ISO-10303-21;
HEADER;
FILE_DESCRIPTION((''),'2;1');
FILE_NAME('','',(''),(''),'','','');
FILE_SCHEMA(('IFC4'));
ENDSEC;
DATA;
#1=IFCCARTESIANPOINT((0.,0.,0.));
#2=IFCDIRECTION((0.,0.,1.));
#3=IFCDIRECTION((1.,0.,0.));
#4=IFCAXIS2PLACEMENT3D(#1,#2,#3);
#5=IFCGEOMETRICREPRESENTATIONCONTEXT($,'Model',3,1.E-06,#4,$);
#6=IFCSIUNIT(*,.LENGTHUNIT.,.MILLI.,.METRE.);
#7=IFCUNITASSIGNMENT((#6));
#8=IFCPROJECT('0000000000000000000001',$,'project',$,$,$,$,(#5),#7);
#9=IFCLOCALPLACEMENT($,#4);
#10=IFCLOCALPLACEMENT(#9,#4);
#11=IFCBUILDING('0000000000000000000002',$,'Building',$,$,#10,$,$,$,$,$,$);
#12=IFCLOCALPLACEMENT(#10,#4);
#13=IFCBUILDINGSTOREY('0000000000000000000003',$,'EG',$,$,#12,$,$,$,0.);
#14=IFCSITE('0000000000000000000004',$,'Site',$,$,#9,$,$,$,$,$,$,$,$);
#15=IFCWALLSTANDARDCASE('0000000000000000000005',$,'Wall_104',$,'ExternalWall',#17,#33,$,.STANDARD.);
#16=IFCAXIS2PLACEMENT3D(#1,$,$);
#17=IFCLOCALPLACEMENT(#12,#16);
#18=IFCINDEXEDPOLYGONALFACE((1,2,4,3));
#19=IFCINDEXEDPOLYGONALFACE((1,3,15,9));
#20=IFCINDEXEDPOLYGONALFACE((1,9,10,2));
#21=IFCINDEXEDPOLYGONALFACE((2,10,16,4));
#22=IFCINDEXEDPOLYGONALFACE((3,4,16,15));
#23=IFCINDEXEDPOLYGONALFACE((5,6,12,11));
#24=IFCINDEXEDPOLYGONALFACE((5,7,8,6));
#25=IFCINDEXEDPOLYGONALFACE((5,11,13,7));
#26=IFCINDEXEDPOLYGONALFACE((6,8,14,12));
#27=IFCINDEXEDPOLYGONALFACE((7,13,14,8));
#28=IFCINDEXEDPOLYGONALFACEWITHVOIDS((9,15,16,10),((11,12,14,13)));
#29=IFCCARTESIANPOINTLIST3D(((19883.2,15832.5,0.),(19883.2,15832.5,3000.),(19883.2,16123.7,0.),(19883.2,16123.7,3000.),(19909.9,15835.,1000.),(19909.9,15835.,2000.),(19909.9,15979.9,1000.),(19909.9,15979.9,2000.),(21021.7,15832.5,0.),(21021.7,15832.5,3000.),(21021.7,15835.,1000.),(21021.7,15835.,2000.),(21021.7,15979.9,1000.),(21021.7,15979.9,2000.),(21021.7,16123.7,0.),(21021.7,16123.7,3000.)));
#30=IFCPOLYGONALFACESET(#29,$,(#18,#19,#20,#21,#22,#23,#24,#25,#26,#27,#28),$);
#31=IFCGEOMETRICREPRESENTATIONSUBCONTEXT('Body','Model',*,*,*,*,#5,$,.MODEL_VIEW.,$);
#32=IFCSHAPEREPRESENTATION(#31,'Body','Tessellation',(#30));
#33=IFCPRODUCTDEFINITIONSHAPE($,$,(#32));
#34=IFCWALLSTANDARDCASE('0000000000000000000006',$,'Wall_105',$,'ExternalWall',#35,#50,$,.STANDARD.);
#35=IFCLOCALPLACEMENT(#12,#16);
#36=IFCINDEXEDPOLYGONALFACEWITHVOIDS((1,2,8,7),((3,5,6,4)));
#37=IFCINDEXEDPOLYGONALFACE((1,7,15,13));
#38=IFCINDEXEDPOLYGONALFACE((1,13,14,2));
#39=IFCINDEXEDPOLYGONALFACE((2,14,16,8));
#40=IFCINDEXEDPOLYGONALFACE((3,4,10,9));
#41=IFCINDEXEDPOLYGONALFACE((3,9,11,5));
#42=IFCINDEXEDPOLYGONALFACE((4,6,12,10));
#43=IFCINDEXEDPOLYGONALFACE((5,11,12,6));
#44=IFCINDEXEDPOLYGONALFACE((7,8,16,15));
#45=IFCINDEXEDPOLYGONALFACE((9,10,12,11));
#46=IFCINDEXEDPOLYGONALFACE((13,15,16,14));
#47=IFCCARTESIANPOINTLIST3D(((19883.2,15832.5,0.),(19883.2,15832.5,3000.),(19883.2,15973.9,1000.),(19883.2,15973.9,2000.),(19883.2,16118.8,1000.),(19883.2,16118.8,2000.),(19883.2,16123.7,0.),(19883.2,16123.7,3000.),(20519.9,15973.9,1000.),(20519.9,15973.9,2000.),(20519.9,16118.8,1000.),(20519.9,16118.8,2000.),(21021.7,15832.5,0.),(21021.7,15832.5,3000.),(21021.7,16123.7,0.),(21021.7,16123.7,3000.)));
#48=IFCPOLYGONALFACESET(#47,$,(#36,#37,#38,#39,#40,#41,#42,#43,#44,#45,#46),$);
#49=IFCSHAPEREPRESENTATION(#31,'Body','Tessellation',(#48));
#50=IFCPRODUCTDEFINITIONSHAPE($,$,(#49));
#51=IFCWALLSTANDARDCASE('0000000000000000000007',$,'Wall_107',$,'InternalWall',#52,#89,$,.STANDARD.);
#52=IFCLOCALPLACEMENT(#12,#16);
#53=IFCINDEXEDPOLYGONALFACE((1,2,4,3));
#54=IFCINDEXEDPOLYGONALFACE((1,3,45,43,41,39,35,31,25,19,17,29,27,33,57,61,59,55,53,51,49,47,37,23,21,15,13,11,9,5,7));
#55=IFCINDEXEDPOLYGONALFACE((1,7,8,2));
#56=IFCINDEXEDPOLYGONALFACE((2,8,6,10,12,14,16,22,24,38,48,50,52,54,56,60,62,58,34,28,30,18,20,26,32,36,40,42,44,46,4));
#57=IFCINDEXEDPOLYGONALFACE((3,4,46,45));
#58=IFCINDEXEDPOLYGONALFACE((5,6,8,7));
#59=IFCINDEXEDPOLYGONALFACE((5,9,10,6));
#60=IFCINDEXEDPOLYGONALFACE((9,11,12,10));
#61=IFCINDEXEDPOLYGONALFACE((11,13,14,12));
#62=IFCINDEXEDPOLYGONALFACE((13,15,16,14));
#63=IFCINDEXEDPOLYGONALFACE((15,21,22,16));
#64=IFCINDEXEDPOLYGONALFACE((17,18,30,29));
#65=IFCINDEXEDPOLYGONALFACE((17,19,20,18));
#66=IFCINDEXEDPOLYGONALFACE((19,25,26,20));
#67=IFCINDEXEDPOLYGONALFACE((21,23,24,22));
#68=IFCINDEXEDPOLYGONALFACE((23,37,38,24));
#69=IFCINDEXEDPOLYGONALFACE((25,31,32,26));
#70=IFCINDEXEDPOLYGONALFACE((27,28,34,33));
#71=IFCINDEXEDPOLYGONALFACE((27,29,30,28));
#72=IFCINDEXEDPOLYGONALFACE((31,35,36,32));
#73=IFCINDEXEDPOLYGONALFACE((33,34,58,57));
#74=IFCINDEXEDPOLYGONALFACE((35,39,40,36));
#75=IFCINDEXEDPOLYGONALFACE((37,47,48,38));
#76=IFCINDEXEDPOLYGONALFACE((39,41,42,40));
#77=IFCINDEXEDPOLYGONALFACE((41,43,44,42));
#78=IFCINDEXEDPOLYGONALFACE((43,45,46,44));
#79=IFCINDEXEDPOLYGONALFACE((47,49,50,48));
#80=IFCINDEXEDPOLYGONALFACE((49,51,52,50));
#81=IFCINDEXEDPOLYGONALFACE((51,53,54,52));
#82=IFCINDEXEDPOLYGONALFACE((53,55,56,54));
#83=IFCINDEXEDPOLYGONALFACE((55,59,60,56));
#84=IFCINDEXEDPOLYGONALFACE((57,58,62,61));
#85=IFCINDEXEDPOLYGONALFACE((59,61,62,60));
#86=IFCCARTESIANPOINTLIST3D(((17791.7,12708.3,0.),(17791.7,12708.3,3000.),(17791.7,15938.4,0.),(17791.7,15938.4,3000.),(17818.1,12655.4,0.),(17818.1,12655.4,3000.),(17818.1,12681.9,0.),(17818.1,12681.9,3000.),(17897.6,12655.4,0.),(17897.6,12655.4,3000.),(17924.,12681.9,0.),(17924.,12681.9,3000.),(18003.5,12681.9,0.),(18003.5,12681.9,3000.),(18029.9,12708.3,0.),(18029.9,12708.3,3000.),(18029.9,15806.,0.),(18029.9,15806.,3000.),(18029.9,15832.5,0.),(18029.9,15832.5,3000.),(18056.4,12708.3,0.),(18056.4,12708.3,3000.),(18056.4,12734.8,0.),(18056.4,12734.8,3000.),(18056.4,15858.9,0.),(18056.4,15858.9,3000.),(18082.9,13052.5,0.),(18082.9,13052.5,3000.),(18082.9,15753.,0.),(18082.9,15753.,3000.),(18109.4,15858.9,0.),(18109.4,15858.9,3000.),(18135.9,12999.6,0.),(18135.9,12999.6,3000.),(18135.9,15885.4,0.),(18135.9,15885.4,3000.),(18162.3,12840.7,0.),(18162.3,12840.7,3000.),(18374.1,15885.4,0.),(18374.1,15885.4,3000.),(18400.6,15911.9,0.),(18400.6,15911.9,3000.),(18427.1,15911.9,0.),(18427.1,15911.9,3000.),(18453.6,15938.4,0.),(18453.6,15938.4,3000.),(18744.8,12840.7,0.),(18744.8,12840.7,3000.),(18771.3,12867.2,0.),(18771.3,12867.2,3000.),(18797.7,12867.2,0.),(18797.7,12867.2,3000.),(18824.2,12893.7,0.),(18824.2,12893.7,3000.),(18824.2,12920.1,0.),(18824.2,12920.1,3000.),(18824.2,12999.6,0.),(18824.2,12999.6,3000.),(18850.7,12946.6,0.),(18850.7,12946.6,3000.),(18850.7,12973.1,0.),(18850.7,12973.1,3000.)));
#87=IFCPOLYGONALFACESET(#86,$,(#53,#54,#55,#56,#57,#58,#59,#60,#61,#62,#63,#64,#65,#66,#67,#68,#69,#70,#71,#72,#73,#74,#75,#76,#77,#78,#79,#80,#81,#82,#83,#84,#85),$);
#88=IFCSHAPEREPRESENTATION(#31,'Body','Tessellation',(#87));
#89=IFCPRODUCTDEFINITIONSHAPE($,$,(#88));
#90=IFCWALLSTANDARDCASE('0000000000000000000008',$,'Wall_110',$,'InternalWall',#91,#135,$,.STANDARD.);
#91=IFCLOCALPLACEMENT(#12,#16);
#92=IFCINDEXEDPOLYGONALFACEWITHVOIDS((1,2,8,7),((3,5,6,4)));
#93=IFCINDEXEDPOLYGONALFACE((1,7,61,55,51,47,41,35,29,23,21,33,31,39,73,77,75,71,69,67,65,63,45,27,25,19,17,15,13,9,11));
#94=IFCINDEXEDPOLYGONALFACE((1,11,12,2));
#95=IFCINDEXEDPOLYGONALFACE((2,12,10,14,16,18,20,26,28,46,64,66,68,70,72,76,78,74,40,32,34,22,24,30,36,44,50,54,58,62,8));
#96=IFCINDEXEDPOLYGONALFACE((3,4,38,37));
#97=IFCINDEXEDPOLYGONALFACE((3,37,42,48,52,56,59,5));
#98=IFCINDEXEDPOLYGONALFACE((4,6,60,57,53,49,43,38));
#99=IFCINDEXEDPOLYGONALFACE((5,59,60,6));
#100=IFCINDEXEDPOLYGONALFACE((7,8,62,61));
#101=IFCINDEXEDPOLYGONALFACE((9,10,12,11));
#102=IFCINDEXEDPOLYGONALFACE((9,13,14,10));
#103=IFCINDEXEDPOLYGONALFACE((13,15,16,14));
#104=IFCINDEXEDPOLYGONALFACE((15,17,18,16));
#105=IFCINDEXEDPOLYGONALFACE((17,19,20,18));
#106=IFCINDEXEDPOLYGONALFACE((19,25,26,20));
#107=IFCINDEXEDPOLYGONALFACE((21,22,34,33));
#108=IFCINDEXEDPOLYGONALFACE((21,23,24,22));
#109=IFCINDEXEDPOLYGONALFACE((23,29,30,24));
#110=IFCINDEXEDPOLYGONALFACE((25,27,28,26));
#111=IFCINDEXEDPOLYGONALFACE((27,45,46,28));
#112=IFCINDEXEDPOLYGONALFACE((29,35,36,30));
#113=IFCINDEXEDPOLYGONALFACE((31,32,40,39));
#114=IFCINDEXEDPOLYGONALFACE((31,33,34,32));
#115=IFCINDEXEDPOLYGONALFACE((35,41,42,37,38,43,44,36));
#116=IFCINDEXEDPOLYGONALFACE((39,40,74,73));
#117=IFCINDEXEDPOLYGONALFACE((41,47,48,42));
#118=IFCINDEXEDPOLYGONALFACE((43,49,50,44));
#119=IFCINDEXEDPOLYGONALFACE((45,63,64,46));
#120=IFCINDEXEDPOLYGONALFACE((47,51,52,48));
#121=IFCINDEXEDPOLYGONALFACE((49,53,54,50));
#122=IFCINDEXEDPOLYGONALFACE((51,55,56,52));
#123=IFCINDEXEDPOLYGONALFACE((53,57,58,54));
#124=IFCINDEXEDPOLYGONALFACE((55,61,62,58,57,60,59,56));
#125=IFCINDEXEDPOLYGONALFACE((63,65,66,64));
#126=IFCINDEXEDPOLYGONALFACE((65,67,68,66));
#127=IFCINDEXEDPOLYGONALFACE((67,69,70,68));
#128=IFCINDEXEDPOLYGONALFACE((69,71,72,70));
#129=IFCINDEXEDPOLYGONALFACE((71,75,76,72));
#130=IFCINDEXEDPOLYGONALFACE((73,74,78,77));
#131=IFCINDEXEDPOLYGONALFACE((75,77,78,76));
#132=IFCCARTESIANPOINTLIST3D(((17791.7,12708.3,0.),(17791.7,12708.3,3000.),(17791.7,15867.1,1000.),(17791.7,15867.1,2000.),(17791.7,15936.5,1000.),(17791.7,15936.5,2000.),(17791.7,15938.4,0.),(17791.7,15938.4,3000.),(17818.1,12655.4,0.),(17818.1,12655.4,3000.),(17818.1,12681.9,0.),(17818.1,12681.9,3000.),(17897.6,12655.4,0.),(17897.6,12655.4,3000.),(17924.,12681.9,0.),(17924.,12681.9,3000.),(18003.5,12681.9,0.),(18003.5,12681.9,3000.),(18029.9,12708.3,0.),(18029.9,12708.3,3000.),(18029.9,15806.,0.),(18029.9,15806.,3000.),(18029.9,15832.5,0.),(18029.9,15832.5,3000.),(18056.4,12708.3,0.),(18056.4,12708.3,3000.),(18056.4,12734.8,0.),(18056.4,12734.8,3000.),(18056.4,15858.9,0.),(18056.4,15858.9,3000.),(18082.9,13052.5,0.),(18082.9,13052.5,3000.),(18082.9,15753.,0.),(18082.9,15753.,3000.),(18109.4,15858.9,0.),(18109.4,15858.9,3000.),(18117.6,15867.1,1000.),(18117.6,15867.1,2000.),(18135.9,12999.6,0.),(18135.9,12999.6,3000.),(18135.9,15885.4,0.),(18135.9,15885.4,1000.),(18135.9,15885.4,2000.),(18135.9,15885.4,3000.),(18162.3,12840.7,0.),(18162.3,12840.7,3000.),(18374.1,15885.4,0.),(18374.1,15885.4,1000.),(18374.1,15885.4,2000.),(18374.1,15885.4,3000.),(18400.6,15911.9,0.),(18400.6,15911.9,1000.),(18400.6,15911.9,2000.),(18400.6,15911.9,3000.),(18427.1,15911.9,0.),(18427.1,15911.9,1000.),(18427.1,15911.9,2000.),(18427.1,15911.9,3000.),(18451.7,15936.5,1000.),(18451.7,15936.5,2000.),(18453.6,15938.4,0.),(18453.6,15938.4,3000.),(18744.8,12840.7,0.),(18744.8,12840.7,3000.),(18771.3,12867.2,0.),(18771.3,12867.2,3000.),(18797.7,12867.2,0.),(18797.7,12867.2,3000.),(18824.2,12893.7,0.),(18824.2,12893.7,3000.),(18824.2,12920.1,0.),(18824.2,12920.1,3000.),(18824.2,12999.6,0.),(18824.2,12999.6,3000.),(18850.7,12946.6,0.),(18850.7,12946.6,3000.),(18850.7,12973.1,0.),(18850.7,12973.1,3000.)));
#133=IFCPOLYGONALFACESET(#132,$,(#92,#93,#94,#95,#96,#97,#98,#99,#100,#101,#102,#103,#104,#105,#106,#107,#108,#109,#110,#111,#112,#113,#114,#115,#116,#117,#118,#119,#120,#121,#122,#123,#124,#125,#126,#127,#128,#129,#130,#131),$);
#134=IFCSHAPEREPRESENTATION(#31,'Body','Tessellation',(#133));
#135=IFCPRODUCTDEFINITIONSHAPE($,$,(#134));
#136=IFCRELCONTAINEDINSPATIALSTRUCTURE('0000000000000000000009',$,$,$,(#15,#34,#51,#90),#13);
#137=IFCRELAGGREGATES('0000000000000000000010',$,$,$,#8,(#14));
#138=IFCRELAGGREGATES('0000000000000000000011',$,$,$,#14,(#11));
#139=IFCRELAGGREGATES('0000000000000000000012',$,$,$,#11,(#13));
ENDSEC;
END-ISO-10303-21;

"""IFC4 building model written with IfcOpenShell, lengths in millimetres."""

from ifc_helpers import new_model, si_unit, frame, origin_with_axes, place, context, subcontext, project, spatial, polyline, rectangle, outline, extrude, element, save


model = new_model("IFC4")

# Units and contexts
model_context = context("Model", 3, precision=1e-06, world=origin_with_axes())
body_context = subcontext(model_context, "Body", "Model", "MODEL_VIEW")
ifc_project = project(units=[si_unit("LENGTHUNIT", "METRE", prefix="MILLI")], contexts=[model_context])

# Site, building, storey
site_placement = place(None, origin_with_axes())
site = spatial("IfcSite", under=ifc_project, at=site_placement, Name="Site")
building_placement = place(site_placement, origin_with_axes())
building = spatial("IfcBuilding", under=site, at=building_placement, Name="Building")
storey_placement = place(building_placement, origin_with_axes())
storey = spatial("IfcBuildingStorey", under=building, at=storey_placement, Name="EG", Elevation=0.0)

# Walls, openings
wall_1_placement = place(storey_placement, origin_with_axes())
wall_1 = element("IfcWallStandardCase", 1, at=wall_1_placement, inside=storey, Name="Wall_104", ObjectType="ExternalWall", PredefinedType="STANDARD", context=body_context, shape_type="SweptSolid", body=[
    extrude(outline(polyline([(19883.2, 15832.5, 0.0), (19883.2, 16123.7, 0.0), (21021.7, 16123.7, 0.0), (21021.7, 15832.5, 0.0), (19883.2, 15832.5, 0.0)])), origin_with_axes(), (0.0, 0.0, 1.0), 3000.0),
])
opening_1_placement = place(wall_1_placement, origin_with_axes())
element("IfcOpeningElement", 2, at=opening_1_placement, inside=storey, cuts=wall_1, context=body_context, shape_type="SweptSolid", body=[
    extrude(rectangle(XDim=2096.8, YDim=144.9), frame((20958.2, 15907.5, 1000.0), z_axis=(0.0, 0.0, 1.0), x_axis=(1.0, 0.0, 0.0)), (0.0, 0.0, 1.0), 1000.0),
])
wall_2_placement = place(storey_placement, origin_with_axes())
wall_2 = element("IfcWallStandardCase", 3, at=wall_2_placement, inside=storey, Name="Wall_105", ObjectType="ExternalWall", PredefinedType="STANDARD", context=body_context, shape_type="SweptSolid", body=[
    extrude(outline(polyline([(19883.2, 15832.5, 0.0), (19883.2, 16123.7, 0.0), (21021.7, 16123.7, 0.0), (21021.7, 15832.5, 0.0), (19883.2, 15832.5, 0.0)])), origin_with_axes(), (0.0, 0.0, 1.0), 3000.0),
])
opening_2_placement = place(wall_2_placement, origin_with_axes())
element("IfcOpeningElement", 4, at=opening_2_placement, inside=storey, cuts=wall_2, context=body_context, shape_type="SweptSolid", body=[
    extrude(rectangle(XDim=1123.3, YDim=144.9), frame((19958.2, 16046.4, 1000.0), z_axis=(0.0, 0.0, 1.0), x_axis=(1.0, 0.0, 0.0)), (0.0, 0.0, 1.0), 1000.0),
])

# Wall
for number, where, z_axis, x_axis, name in (
    (5, (0.0, 0.0, 0.0), (0.0, 0.0, 1.0), (1.0, 0.0, 0.0), "Wall_107"),
):
    element("IfcWallStandardCase", number, at=place(storey_placement, frame(where, z_axis=z_axis, x_axis=x_axis)), inside=storey, Name=name, ObjectType="InternalWall", PredefinedType="STANDARD", context=body_context, shape_type="SweptSolid", body=[
        extrude(outline(polyline([(17818.1, 12655.4, 0.0), (17818.1, 12681.9, 0.0), (17791.7, 12708.3, 0.0), (17791.7, 15938.4, 0.0), (18453.6, 15938.4, 0.0), (18427.1, 15911.9, 0.0), (18400.6, 15911.9, 0.0), (18374.1, 15885.4, 0.0), (18135.9, 15885.4, 0.0), (18109.4, 15858.9, 0.0), (18056.4, 15858.9, 0.0), (18029.9, 15832.5, 0.0), (18029.9, 15806.0, 0.0), (18082.9, 15753.0, 0.0), (18082.9, 13052.5, 0.0), (18135.9, 12999.6, 0.0), (18824.2, 12999.6, 0.0), (18850.7, 12973.1, 0.0), (18850.7, 12946.6, 0.0), (18824.2, 12920.1, 0.0), (18824.2, 12893.7, 0.0), (18797.7, 12867.2, 0.0), (18771.3, 12867.2, 0.0), (18744.8, 12840.7, 0.0), (18162.3, 12840.7, 0.0), (18056.4, 12734.8, 0.0), (18056.4, 12708.3, 0.0), (18029.9, 12708.3, 0.0), (18003.5, 12681.9, 0.0), (17924.0, 12681.9, 0.0), (17897.6, 12655.4, 0.0), (17818.1, 12655.4, 0.0)])), origin_with_axes(), (0.0, 0.0, 1.0), 3000.0),
    ])

# Wall, opening
wall_3_placement = place(storey_placement, origin_with_axes())
wall_3 = element("IfcWallStandardCase", 6, at=wall_3_placement, inside=storey, Name="Wall_110", ObjectType="InternalWall", PredefinedType="STANDARD", context=body_context, shape_type="SweptSolid", body=[
    extrude(outline(polyline([(17818.1, 12655.4, 0.0), (17818.1, 12681.9, 0.0), (17791.7, 12708.3, 0.0), (17791.7, 15938.4, 0.0), (18453.6, 15938.4, 0.0), (18427.1, 15911.9, 0.0), (18400.6, 15911.9, 0.0), (18374.1, 15885.4, 0.0), (18135.9, 15885.4, 0.0), (18109.4, 15858.9, 0.0), (18056.4, 15858.9, 0.0), (18029.9, 15832.5, 0.0), (18029.9, 15806.0, 0.0), (18082.9, 15753.0, 0.0), (18082.9, 13052.5, 0.0), (18135.9, 12999.6, 0.0), (18824.2, 12999.6, 0.0), (18850.7, 12973.1, 0.0), (18850.7, 12946.6, 0.0), (18824.2, 12920.1, 0.0), (18824.2, 12893.7, 0.0), (18797.7, 12867.2, 0.0), (18771.3, 12867.2, 0.0), (18744.8, 12840.7, 0.0), (18162.3, 12840.7, 0.0), (18056.4, 12734.8, 0.0), (18056.4, 12708.3, 0.0), (18029.9, 12708.3, 0.0), (18003.5, 12681.9, 0.0), (17924.0, 12681.9, 0.0), (17897.6, 12655.4, 0.0), (17818.1, 12655.4, 0.0)])), origin_with_axes(), (0.0, 0.0, 1.0), 3000.0),
])
opening_3_placement = place(wall_3_placement, origin_with_axes())
element("IfcOpeningElement", 7, at=opening_3_placement, inside=storey, cuts=wall_3, context=body_context, shape_type="SweptSolid", body=[
    extrude(rectangle(XDim=1985.7, YDim=69.4), frame((18269.4, 15901.8, 1000.0), z_axis=(0.0, 0.0, 1.0), x_axis=(1.0, 0.0, 0.0)), (0.0, 0.0, 1.0), 1000.0),
])

save(model, "model.ifc")
